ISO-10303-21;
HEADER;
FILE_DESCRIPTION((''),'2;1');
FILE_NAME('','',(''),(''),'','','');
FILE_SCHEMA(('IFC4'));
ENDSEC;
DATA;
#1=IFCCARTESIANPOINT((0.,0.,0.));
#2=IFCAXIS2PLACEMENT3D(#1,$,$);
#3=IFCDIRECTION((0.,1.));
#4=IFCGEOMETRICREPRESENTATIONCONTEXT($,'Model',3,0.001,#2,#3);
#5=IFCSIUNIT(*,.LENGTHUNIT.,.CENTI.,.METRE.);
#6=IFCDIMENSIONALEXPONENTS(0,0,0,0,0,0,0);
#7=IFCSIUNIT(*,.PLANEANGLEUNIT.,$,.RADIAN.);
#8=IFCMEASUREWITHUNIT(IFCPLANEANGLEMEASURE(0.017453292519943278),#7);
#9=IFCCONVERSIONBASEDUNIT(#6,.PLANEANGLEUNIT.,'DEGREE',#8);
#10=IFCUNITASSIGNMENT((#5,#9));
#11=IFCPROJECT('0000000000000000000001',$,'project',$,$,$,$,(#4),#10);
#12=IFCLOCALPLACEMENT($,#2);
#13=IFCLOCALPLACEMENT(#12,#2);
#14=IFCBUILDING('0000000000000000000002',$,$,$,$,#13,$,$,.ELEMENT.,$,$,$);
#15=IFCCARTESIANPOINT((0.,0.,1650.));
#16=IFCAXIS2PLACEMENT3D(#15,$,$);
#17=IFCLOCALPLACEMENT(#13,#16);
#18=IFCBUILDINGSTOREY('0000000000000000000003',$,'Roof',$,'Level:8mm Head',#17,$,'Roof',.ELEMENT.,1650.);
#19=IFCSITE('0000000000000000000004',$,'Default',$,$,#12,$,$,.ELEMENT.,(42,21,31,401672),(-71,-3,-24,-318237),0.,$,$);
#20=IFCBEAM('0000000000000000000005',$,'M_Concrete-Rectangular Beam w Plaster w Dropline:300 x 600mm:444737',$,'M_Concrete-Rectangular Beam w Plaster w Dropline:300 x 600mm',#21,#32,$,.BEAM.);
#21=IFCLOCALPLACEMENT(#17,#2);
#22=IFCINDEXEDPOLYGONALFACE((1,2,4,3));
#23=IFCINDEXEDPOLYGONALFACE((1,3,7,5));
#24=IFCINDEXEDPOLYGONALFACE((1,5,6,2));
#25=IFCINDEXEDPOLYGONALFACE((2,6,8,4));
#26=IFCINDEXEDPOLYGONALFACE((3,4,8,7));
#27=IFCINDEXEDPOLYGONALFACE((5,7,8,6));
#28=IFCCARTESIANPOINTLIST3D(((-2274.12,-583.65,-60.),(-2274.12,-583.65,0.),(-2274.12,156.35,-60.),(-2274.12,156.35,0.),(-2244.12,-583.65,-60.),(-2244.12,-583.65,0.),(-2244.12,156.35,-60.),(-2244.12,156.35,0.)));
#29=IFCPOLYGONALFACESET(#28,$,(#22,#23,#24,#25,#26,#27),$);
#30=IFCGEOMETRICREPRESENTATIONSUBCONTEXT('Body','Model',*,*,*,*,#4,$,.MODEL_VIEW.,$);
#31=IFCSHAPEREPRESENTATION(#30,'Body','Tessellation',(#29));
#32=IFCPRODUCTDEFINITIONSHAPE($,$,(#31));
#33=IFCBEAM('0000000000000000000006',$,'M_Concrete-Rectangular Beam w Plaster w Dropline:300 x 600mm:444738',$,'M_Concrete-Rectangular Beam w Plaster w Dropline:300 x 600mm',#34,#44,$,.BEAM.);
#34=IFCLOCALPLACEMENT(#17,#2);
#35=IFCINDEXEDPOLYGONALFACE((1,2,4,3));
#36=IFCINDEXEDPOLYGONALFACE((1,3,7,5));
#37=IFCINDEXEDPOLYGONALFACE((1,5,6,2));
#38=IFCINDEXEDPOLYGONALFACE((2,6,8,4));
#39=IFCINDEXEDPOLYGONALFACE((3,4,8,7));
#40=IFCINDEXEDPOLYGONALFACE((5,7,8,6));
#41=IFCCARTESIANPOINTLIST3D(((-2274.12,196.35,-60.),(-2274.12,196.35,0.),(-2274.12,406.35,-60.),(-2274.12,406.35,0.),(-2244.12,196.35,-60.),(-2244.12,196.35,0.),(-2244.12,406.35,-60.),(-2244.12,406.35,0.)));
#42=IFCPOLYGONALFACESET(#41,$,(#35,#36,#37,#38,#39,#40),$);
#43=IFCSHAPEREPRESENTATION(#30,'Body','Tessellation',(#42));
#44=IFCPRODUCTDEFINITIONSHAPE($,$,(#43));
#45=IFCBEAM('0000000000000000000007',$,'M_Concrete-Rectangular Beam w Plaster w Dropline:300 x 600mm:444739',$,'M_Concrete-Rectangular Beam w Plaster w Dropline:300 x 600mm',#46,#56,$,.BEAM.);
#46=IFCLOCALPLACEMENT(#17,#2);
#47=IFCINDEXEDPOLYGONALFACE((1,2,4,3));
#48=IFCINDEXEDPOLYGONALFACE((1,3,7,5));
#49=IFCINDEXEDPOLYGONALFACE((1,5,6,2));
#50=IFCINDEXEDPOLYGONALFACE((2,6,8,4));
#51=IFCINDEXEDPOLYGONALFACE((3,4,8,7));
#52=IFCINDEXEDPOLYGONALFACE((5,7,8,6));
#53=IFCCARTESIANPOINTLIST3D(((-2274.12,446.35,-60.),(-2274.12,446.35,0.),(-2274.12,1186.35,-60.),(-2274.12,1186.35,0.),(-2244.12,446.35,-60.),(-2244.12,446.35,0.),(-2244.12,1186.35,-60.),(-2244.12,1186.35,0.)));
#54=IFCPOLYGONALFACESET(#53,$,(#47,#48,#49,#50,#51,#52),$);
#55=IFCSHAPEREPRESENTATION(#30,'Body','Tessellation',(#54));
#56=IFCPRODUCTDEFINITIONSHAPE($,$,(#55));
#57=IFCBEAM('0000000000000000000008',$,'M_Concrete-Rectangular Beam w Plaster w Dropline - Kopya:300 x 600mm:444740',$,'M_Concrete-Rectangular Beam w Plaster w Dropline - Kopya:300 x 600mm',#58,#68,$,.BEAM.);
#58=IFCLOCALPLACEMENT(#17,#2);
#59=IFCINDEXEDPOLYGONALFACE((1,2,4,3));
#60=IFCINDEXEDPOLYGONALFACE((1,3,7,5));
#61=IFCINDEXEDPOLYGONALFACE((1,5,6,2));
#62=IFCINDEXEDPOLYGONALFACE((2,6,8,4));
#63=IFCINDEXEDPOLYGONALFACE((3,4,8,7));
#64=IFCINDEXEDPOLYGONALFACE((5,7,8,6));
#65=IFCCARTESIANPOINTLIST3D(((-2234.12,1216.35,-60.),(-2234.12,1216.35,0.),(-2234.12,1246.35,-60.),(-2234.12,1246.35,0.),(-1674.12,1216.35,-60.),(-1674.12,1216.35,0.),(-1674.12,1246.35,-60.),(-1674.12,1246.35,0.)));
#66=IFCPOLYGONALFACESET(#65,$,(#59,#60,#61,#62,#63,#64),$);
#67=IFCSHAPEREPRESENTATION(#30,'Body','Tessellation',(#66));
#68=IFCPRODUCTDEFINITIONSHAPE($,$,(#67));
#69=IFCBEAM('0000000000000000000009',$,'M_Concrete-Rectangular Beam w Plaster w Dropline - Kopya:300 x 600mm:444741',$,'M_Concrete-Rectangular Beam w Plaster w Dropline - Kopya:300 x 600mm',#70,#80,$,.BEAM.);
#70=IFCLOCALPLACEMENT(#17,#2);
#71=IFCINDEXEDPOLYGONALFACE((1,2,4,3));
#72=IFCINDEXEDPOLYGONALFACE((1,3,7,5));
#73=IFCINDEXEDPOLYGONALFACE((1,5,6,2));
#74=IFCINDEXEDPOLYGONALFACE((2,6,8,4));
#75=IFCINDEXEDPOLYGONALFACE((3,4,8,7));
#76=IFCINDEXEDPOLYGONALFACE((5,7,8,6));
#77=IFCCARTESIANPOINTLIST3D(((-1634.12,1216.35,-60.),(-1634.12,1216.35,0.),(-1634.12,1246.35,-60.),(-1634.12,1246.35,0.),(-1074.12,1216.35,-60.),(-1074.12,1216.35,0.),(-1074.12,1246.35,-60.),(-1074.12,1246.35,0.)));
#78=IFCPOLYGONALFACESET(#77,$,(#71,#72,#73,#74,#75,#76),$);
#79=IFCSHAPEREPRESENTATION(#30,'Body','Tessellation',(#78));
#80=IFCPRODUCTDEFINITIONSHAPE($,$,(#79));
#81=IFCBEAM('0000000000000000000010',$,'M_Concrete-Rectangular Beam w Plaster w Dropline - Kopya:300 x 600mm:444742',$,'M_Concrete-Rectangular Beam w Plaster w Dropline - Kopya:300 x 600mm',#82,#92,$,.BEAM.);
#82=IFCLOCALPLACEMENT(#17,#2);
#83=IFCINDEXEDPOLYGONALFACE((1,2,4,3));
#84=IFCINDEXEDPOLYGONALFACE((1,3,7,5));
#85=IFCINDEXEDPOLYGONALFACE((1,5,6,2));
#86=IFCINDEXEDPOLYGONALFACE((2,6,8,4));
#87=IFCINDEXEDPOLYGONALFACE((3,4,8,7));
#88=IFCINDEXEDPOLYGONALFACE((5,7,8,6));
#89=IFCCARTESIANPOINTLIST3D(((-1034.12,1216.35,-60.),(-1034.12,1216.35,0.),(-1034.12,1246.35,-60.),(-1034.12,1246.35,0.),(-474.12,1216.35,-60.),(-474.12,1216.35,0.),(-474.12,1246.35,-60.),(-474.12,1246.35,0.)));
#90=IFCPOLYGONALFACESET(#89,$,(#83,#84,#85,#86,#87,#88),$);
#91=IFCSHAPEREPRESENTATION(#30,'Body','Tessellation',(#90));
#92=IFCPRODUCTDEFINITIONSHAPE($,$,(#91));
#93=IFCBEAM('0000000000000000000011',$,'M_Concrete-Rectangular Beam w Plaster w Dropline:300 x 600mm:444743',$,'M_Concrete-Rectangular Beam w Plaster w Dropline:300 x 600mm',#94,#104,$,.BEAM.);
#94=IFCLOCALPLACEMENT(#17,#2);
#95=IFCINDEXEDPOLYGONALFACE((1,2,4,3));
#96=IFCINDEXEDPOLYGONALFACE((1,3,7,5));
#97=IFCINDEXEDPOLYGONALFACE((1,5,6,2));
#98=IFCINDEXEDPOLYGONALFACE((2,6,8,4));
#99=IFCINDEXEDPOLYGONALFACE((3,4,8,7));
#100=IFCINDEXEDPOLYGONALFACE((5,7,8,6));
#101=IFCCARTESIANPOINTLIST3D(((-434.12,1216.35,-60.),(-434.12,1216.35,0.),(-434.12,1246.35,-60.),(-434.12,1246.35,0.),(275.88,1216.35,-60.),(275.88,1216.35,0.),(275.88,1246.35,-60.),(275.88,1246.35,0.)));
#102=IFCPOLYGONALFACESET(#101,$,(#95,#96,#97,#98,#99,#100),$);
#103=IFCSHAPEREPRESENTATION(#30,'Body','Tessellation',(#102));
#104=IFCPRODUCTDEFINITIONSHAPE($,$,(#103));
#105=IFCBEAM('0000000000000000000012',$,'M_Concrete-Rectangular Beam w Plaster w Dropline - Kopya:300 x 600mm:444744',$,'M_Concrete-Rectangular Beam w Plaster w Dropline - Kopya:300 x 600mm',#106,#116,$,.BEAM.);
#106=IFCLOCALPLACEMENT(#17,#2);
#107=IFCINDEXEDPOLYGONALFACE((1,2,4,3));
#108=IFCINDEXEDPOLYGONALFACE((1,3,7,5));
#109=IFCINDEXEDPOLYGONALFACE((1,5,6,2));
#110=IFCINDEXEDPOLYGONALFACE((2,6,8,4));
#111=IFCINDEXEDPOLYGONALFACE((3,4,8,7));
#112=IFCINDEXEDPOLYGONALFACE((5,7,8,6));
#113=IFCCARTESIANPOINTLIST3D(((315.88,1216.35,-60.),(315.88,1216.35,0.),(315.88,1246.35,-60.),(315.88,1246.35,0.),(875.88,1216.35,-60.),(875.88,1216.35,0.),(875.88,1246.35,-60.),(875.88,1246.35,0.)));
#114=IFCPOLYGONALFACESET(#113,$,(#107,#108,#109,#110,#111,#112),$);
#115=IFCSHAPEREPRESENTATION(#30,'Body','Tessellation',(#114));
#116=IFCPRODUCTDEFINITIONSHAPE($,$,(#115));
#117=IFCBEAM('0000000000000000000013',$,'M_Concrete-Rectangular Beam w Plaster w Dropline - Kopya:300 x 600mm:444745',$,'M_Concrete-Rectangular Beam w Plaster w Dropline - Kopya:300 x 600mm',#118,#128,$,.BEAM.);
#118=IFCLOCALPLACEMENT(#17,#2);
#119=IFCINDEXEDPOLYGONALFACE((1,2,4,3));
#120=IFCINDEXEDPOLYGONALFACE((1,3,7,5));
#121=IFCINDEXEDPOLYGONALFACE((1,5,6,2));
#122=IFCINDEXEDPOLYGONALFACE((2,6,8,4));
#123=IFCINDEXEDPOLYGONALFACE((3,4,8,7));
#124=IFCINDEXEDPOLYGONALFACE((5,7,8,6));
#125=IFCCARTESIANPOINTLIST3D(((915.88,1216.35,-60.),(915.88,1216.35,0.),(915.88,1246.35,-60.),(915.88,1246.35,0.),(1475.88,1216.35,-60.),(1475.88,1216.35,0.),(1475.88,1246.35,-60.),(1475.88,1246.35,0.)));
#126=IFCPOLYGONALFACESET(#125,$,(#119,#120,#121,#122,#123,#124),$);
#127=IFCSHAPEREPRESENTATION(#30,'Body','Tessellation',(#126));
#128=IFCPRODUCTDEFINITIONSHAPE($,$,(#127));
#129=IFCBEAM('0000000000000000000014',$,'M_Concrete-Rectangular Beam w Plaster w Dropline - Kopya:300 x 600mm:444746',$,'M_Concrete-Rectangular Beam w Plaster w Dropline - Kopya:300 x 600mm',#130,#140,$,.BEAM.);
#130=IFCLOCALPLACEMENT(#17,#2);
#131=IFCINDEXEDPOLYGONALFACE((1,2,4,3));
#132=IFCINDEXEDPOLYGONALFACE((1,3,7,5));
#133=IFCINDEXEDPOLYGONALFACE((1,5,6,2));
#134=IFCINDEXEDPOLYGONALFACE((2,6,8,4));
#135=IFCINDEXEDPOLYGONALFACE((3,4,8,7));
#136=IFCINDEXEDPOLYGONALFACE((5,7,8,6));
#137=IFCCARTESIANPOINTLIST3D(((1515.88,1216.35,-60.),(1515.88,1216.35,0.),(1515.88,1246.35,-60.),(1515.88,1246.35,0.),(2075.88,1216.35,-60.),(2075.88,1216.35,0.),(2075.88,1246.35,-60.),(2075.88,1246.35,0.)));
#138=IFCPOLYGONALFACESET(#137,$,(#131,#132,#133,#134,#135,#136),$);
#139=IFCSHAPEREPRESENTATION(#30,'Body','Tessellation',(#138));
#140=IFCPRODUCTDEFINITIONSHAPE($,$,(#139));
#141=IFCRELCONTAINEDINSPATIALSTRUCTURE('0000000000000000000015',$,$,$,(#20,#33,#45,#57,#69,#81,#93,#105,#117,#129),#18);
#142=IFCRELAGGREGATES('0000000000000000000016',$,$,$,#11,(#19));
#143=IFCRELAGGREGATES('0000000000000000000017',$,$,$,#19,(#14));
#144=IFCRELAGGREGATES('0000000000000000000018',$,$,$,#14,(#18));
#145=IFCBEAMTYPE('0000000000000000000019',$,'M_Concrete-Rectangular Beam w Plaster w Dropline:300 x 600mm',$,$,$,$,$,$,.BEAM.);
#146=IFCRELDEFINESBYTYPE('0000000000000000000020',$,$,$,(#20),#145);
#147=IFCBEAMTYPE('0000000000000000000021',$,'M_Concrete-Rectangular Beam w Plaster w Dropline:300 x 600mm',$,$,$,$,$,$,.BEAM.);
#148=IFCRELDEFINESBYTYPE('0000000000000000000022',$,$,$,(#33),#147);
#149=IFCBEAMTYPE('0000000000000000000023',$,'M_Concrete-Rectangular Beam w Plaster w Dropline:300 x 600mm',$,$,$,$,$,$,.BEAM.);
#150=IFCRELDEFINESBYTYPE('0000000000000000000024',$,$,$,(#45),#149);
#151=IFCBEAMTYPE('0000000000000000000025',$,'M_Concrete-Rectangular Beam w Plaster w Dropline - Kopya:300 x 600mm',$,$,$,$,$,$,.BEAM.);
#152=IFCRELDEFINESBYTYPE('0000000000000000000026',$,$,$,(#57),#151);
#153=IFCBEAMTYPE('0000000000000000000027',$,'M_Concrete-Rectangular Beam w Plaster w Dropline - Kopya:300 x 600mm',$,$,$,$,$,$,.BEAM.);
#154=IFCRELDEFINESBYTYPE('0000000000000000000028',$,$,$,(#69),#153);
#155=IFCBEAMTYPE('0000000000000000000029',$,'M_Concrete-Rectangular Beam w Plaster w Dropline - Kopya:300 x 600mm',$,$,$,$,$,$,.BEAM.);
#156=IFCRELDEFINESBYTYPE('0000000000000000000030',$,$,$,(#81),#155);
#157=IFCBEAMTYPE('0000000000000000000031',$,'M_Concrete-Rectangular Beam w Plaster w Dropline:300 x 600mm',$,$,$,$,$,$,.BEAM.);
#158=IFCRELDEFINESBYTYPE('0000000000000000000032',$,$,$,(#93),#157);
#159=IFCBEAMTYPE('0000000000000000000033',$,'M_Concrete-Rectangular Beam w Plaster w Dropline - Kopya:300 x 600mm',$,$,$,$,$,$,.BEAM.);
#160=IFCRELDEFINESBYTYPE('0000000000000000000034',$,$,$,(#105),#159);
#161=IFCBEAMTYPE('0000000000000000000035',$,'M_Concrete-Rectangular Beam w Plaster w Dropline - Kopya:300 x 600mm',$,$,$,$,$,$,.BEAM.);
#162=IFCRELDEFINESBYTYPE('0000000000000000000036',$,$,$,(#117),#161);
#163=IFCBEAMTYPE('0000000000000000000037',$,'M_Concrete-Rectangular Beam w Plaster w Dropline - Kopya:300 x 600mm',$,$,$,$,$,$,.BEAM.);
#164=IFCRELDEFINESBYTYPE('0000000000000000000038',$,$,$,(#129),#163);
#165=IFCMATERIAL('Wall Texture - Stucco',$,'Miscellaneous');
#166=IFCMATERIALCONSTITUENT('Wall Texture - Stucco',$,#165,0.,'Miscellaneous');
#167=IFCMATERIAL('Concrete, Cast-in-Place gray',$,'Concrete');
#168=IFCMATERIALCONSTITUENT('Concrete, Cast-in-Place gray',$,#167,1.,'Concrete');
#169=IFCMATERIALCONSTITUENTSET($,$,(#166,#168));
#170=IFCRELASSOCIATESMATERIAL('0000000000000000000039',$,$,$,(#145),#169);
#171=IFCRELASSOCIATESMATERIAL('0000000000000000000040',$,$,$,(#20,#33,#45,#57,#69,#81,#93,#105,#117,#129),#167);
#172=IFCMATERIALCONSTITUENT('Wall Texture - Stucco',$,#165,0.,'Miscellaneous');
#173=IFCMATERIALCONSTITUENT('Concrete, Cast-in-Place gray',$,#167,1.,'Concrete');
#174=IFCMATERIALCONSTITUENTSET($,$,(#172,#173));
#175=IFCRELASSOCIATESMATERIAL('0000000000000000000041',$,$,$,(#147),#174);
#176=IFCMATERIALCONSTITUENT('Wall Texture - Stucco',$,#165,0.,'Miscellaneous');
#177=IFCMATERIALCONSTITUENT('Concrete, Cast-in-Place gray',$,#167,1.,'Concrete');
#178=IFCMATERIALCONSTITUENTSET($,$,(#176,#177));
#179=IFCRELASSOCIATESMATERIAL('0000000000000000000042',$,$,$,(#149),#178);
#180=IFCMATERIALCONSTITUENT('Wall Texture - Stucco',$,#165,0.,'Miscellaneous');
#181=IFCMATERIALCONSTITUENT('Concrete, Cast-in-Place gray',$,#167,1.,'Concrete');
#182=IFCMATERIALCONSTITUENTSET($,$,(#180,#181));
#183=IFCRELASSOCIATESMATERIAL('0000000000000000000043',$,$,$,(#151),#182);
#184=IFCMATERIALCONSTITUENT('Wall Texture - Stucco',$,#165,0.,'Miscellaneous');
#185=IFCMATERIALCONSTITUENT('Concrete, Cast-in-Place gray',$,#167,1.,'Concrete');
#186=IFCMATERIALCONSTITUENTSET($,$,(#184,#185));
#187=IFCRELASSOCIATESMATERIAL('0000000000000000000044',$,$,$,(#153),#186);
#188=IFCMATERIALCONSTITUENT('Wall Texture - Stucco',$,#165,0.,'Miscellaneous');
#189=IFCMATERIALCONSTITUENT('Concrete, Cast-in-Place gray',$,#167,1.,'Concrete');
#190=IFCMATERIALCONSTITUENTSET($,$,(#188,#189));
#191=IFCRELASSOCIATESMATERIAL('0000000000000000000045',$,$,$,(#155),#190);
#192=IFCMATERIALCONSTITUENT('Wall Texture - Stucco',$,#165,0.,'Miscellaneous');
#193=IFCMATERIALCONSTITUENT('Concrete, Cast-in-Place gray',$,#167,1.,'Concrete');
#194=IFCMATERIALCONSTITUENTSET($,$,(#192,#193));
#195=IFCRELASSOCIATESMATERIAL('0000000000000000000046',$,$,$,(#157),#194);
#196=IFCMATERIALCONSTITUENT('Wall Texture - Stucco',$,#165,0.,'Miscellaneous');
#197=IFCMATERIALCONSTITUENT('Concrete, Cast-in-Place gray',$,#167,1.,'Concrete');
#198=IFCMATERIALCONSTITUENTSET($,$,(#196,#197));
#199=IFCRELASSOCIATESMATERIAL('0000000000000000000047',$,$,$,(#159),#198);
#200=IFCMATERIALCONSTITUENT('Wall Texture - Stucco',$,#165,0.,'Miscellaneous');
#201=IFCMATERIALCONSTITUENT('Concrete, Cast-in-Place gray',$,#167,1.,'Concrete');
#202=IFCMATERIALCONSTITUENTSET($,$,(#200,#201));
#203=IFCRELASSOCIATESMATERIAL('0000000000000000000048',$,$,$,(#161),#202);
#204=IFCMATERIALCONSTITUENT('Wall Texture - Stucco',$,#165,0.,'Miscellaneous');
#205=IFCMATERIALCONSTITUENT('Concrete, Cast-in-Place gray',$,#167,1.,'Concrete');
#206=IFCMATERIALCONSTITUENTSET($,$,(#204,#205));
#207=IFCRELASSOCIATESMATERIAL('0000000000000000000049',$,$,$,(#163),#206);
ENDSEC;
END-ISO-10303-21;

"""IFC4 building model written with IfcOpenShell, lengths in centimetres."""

from ifc_helpers import new_model, entity, si_unit, converted_unit, direction, frame, origin, place, context, subcontext, project, spatial, indexed_curve, outline, extrude, source, transform, mapped, material, constituent, constituent_set, type_object, type_shapes, element, save


model = new_model("IFC4")

# Units and contexts
model_context = context("Model", 3, precision=0.001, world=origin(), true_north=direction((0.0, 1.0)))
body_context = subcontext(model_context, "Body", "Model", "MODEL_VIEW")
ifc_project = project(units=[si_unit("LENGTHUNIT", "METRE", prefix="CENTI"), converted_unit("PLANEANGLEUNIT", "DEGREE", entity("IfcPlaneAngleMeasure", 0.017453292519943278), si_unit("PLANEANGLEUNIT", "RADIAN"), dimensions=[0, 0, 0, 0, 0, 0, 0])], contexts=[model_context])

# Site, building, storey
site_placement = place(None, origin())
site = spatial("IfcSite", under=ifc_project, at=site_placement, Name="Default", CompositionType="ELEMENT", RefLatitude=(42, 21, 31, 401672), RefLongitude=(-71, -3, -24, -318237), RefElevation=0.0)
building_placement = place(site_placement, origin())
building = spatial("IfcBuilding", under=site, at=building_placement, CompositionType="ELEMENT")
storey_placement = place(building_placement, frame((0.0, 0.0, 1650.0)))
storey = spatial("IfcBuildingStorey", under=building, at=storey_placement, Name="Roof", ObjectType="Level:8mm Head", LongName="Roof", CompositionType="ELEMENT", Elevation=1650.0)

# Beams
ifc_material_1 = material(Name="Concrete, Cast-in-Place gray", Category="Concrete")
ifc_material_2 = material(Name="Wall Texture - Stucco", Category="Miscellaneous")
ifc_constituent_1 = constituent(ifc_material_2, Name="Wall Texture - Stucco", Category="Miscellaneous", fraction=0.0)
ifc_constituent_2 = constituent(ifc_material_1, Name="Concrete, Cast-in-Place gray", Category="Concrete", fraction=1.0)
ifc_constituent_set_1 = constituent_set(constituents=[ifc_constituent_1, ifc_constituent_2])
beam_type_1 = type_object("IfcBeamType", Name="M_Concrete-Rectangular Beam w Plaster w Dropline:300 x 600mm", PredefinedType="BEAM", material=ifc_constituent_set_1)
shared_shape_1 = source(origin(), body_context, "Body", "SweptSolid", [
    extrude(outline(indexed_curve([(-15.0, -30.0), (15.0, -30.0), (15.0, 30.0), (-15.0, 30.0), (-15.0, -30.0)], self_intersect=False)), frame((-2259.12, -583.65, 1620.0), z_axis=(0.0, 1.0, 0.0), x_axis=(-1.0, 0.0, 0.0)), (0.0, 0.0, 1.0), 740.0),
])
type_shapes(beam_type_1, [shared_shape_1])
beam_1_placement = place(storey_placement, frame((0.0, 0.0, -1650.0)))
element("IfcBeam", 1, at=beam_1_placement, inside=storey, type_object=beam_type_1, material=ifc_material_1, Name="M_Concrete-Rectangular Beam w Plaster w Dropline:300 x 600mm:444737", ObjectType="M_Concrete-Rectangular Beam w Plaster w Dropline:300 x 600mm", PredefinedType="BEAM", context=body_context, shape_type="MappedRepresentation", body=[
    mapped(shared_shape_1, transform((0.0, 0.0, 0.0), scale=1.0)),
])
ifc_constituent_3 = constituent(ifc_material_2, Name="Wall Texture - Stucco", Category="Miscellaneous", fraction=0.0)
ifc_constituent_4 = constituent(ifc_material_1, Name="Concrete, Cast-in-Place gray", Category="Concrete", fraction=1.0)
ifc_constituent_set_2 = constituent_set(constituents=[ifc_constituent_3, ifc_constituent_4])
beam_type_2 = type_object("IfcBeamType", Name="M_Concrete-Rectangular Beam w Plaster w Dropline:300 x 600mm", PredefinedType="BEAM", material=ifc_constituent_set_2)
shared_shape_2 = source(origin(), body_context, "Body", "SweptSolid", [
    extrude(outline(indexed_curve([(-15.0, -30.0), (15.0, -30.0), (15.0, 30.0), (-15.0, 30.0), (-15.0, -30.0)], self_intersect=False)), frame((-2259.12, 196.35, 1620.0), z_axis=(0.0, 1.0, 0.0), x_axis=(-1.0, 0.0, 0.0)), (0.0, 0.0, 1.0), 210.0),
])
type_shapes(beam_type_2, [shared_shape_2])
beam_2_placement = place(storey_placement, frame((0.0, 0.0, -1650.0)))
element("IfcBeam", 2, at=beam_2_placement, inside=storey, type_object=beam_type_2, material=ifc_material_1, Name="M_Concrete-Rectangular Beam w Plaster w Dropline:300 x 600mm:444738", ObjectType="M_Concrete-Rectangular Beam w Plaster w Dropline:300 x 600mm", PredefinedType="BEAM", context=body_context, shape_type="MappedRepresentation", body=[
    mapped(shared_shape_2, transform((0.0, 0.0, 0.0), scale=1.0)),
])
ifc_constituent_5 = constituent(ifc_material_2, Name="Wall Texture - Stucco", Category="Miscellaneous", fraction=0.0)
ifc_constituent_6 = constituent(ifc_material_1, Name="Concrete, Cast-in-Place gray", Category="Concrete", fraction=1.0)
ifc_constituent_set_3 = constituent_set(constituents=[ifc_constituent_5, ifc_constituent_6])
beam_type_3 = type_object("IfcBeamType", Name="M_Concrete-Rectangular Beam w Plaster w Dropline:300 x 600mm", PredefinedType="BEAM", material=ifc_constituent_set_3)
shared_shape_3 = source(origin(), body_context, "Body", "SweptSolid", [
    extrude(outline(indexed_curve([(-15.0, -30.0), (15.0, -30.0), (15.0, 30.0), (-15.0, 30.0), (-15.0, -30.0)], self_intersect=False)), frame((-2259.12, 446.35, 1620.0), z_axis=(0.0, 1.0, 0.0), x_axis=(-1.0, 0.0, 0.0)), (0.0, 0.0, 1.0), 740.0),
])
type_shapes(beam_type_3, [shared_shape_3])
beam_3_placement = place(storey_placement, frame((0.0, 0.0, -1650.0)))
element("IfcBeam", 3, at=beam_3_placement, inside=storey, type_object=beam_type_3, material=ifc_material_1, Name="M_Concrete-Rectangular Beam w Plaster w Dropline:300 x 600mm:444739", ObjectType="M_Concrete-Rectangular Beam w Plaster w Dropline:300 x 600mm", PredefinedType="BEAM", context=body_context, shape_type="MappedRepresentation", body=[
    mapped(shared_shape_3, transform((0.0, 0.0, 0.0), scale=1.0)),
])
ifc_constituent_7 = constituent(ifc_material_2, Name="Wall Texture - Stucco", Category="Miscellaneous", fraction=0.0)
ifc_constituent_8 = constituent(ifc_material_1, Name="Concrete, Cast-in-Place gray", Category="Concrete", fraction=1.0)
ifc_constituent_set_4 = constituent_set(constituents=[ifc_constituent_7, ifc_constituent_8])
beam_type_4 = type_object("IfcBeamType", Name="M_Concrete-Rectangular Beam w Plaster w Dropline - Kopya:300 x 600mm", PredefinedType="BEAM", material=ifc_constituent_set_4)
shared_shape_4 = source(origin(), body_context, "Body", "SweptSolid", [
    extrude(outline(indexed_curve([(-30.0, -15.0), (30.0, -15.0), (30.0, 15.0), (-30.0, 15.0), (-30.0, -15.0)], self_intersect=False)), frame((-2234.12, 1231.35, 1620.0), z_axis=(1.0, 0.0, 0.0), x_axis=(0.0, 0.0, -1.0)), (0.0, 0.0, 1.0), 560.0),
])
type_shapes(beam_type_4, [shared_shape_4])
beam_4_placement = place(storey_placement, frame((0.0, 0.0, -1650.0)))
element("IfcBeam", 4, at=beam_4_placement, inside=storey, type_object=beam_type_4, material=ifc_material_1, Name="M_Concrete-Rectangular Beam w Plaster w Dropline - Kopya:300 x 600mm:444740", ObjectType="M_Concrete-Rectangular Beam w Plaster w Dropline - Kopya:300 x 600mm", PredefinedType="BEAM", context=body_context, shape_type="MappedRepresentation", body=[
    mapped(shared_shape_4, transform((0.0, 0.0, 0.0), scale=1.0)),
])
ifc_constituent_9 = constituent(ifc_material_2, Name="Wall Texture - Stucco", Category="Miscellaneous", fraction=0.0)
ifc_constituent_10 = constituent(ifc_material_1, Name="Concrete, Cast-in-Place gray", Category="Concrete", fraction=1.0)
ifc_constituent_set_5 = constituent_set(constituents=[ifc_constituent_9, ifc_constituent_10])
beam_type_5 = type_object("IfcBeamType", Name="M_Concrete-Rectangular Beam w Plaster w Dropline - Kopya:300 x 600mm", PredefinedType="BEAM", material=ifc_constituent_set_5)
shared_shape_5 = source(origin(), body_context, "Body", "SweptSolid", [
    extrude(outline(indexed_curve([(-30.0, -15.0), (30.0, -15.0), (30.0, 15.0), (-30.0, 15.0), (-30.0, -15.0)], self_intersect=False)), frame((-1634.12, 1231.35, 1620.0), z_axis=(1.0, 0.0, 0.0), x_axis=(0.0, 0.0, -1.0)), (0.0, 0.0, 1.0), 560.0),
])
type_shapes(beam_type_5, [shared_shape_5])
beam_5_placement = place(storey_placement, frame((0.0, 0.0, -1650.0)))
element("IfcBeam", 5, at=beam_5_placement, inside=storey, type_object=beam_type_5, material=ifc_material_1, Name="M_Concrete-Rectangular Beam w Plaster w Dropline - Kopya:300 x 600mm:444741", ObjectType="M_Concrete-Rectangular Beam w Plaster w Dropline - Kopya:300 x 600mm", PredefinedType="BEAM", context=body_context, shape_type="MappedRepresentation", body=[
    mapped(shared_shape_5, transform((0.0, 0.0, 0.0), scale=1.0)),
])
ifc_constituent_11 = constituent(ifc_material_2, Name="Wall Texture - Stucco", Category="Miscellaneous", fraction=0.0)
ifc_constituent_12 = constituent(ifc_material_1, Name="Concrete, Cast-in-Place gray", Category="Concrete", fraction=1.0)
ifc_constituent_set_6 = constituent_set(constituents=[ifc_constituent_11, ifc_constituent_12])
beam_type_6 = type_object("IfcBeamType", Name="M_Concrete-Rectangular Beam w Plaster w Dropline - Kopya:300 x 600mm", PredefinedType="BEAM", material=ifc_constituent_set_6)
shared_shape_6 = source(origin(), body_context, "Body", "SweptSolid", [
    extrude(outline(indexed_curve([(-30.0, -15.0), (30.0, -15.0), (30.0, 15.0), (-30.0, 15.0), (-30.0, -15.0)], self_intersect=False)), frame((-1034.12, 1231.35, 1620.0), z_axis=(1.0, 0.0, 0.0), x_axis=(0.0, 0.0, -1.0)), (0.0, 0.0, 1.0), 560.0),
])
type_shapes(beam_type_6, [shared_shape_6])
beam_6_placement = place(storey_placement, frame((0.0, 0.0, -1650.0)))
element("IfcBeam", 6, at=beam_6_placement, inside=storey, type_object=beam_type_6, material=ifc_material_1, Name="M_Concrete-Rectangular Beam w Plaster w Dropline - Kopya:300 x 600mm:444742", ObjectType="M_Concrete-Rectangular Beam w Plaster w Dropline - Kopya:300 x 600mm", PredefinedType="BEAM", context=body_context, shape_type="MappedRepresentation", body=[
    mapped(shared_shape_6, transform((0.0, 0.0, 0.0), scale=1.0)),
])
ifc_constituent_13 = constituent(ifc_material_2, Name="Wall Texture - Stucco", Category="Miscellaneous", fraction=0.0)
ifc_constituent_14 = constituent(ifc_material_1, Name="Concrete, Cast-in-Place gray", Category="Concrete", fraction=1.0)
ifc_constituent_set_7 = constituent_set(constituents=[ifc_constituent_13, ifc_constituent_14])
beam_type_7 = type_object("IfcBeamType", Name="M_Concrete-Rectangular Beam w Plaster w Dropline:300 x 600mm", PredefinedType="BEAM", material=ifc_constituent_set_7)
shared_shape_7 = source(origin(), body_context, "Body", "SweptSolid", [
    extrude(outline(indexed_curve([(-30.0, -15.0), (30.0, -15.0), (30.0, 15.0), (-30.0, 15.0), (-30.0, -15.0)], self_intersect=False)), frame((-434.12, 1231.35, 1620.0), z_axis=(1.0, 0.0, 0.0), x_axis=(0.0, 0.0, -1.0)), (0.0, 0.0, 1.0), 710.0),
])
type_shapes(beam_type_7, [shared_shape_7])
beam_7_placement = place(storey_placement, frame((0.0, 0.0, -1650.0)))
element("IfcBeam", 7, at=beam_7_placement, inside=storey, type_object=beam_type_7, material=ifc_material_1, Name="M_Concrete-Rectangular Beam w Plaster w Dropline:300 x 600mm:444743", ObjectType="M_Concrete-Rectangular Beam w Plaster w Dropline:300 x 600mm", PredefinedType="BEAM", context=body_context, shape_type="MappedRepresentation", body=[
    mapped(shared_shape_7, transform((0.0, 0.0, 0.0), scale=1.0)),
])
ifc_constituent_15 = constituent(ifc_material_2, Name="Wall Texture - Stucco", Category="Miscellaneous", fraction=0.0)
ifc_constituent_16 = constituent(ifc_material_1, Name="Concrete, Cast-in-Place gray", Category="Concrete", fraction=1.0)
ifc_constituent_set_8 = constituent_set(constituents=[ifc_constituent_15, ifc_constituent_16])
beam_type_8 = type_object("IfcBeamType", Name="M_Concrete-Rectangular Beam w Plaster w Dropline - Kopya:300 x 600mm", PredefinedType="BEAM", material=ifc_constituent_set_8)
shared_shape_8 = source(origin(), body_context, "Body", "SweptSolid", [
    extrude(outline(indexed_curve([(-30.0, -15.0), (30.0, -15.0), (30.0, 15.0), (-30.0, 15.0), (-30.0, -15.0)], self_intersect=False)), frame((315.88, 1231.35, 1620.0), z_axis=(1.0, 0.0, 0.0), x_axis=(0.0, 0.0, -1.0)), (0.0, 0.0, 1.0), 560.0),
])
type_shapes(beam_type_8, [shared_shape_8])
beam_8_placement = place(storey_placement, frame((0.0, 0.0, -1650.0)))
element("IfcBeam", 8, at=beam_8_placement, inside=storey, type_object=beam_type_8, material=ifc_material_1, Name="M_Concrete-Rectangular Beam w Plaster w Dropline - Kopya:300 x 600mm:444744", ObjectType="M_Concrete-Rectangular Beam w Plaster w Dropline - Kopya:300 x 600mm", PredefinedType="BEAM", context=body_context, shape_type="MappedRepresentation", body=[
    mapped(shared_shape_8, transform((0.0, 0.0, 0.0), scale=1.0)),
])
ifc_constituent_17 = constituent(ifc_material_2, Name="Wall Texture - Stucco", Category="Miscellaneous", fraction=0.0)
ifc_constituent_18 = constituent(ifc_material_1, Name="Concrete, Cast-in-Place gray", Category="Concrete", fraction=1.0)
ifc_constituent_set_9 = constituent_set(constituents=[ifc_constituent_17, ifc_constituent_18])
beam_type_9 = type_object("IfcBeamType", Name="M_Concrete-Rectangular Beam w Plaster w Dropline - Kopya:300 x 600mm", PredefinedType="BEAM", material=ifc_constituent_set_9)
shared_shape_9 = source(origin(), body_context, "Body", "SweptSolid", [
    extrude(outline(indexed_curve([(-30.0, -15.0), (30.0, -15.0), (30.0, 15.0), (-30.0, 15.0), (-30.0, -15.0)], self_intersect=False)), frame((915.88, 1231.35, 1620.0), z_axis=(1.0, 0.0, 0.0), x_axis=(0.0, 0.0, -1.0)), (0.0, 0.0, 1.0), 560.0),
])
type_shapes(beam_type_9, [shared_shape_9])
beam_9_placement = place(storey_placement, frame((0.0, 0.0, -1650.0)))
element("IfcBeam", 9, at=beam_9_placement, inside=storey, type_object=beam_type_9, material=ifc_material_1, Name="M_Concrete-Rectangular Beam w Plaster w Dropline - Kopya:300 x 600mm:444745", ObjectType="M_Concrete-Rectangular Beam w Plaster w Dropline - Kopya:300 x 600mm", PredefinedType="BEAM", context=body_context, shape_type="MappedRepresentation", body=[
    mapped(shared_shape_9, transform((0.0, 0.0, 0.0), scale=1.0)),
])
ifc_constituent_19 = constituent(ifc_material_2, Name="Wall Texture - Stucco", Category="Miscellaneous", fraction=0.0)
ifc_constituent_20 = constituent(ifc_material_1, Name="Concrete, Cast-in-Place gray", Category="Concrete", fraction=1.0)
ifc_constituent_set_10 = constituent_set(constituents=[ifc_constituent_19, ifc_constituent_20])
beam_type_10 = type_object("IfcBeamType", Name="M_Concrete-Rectangular Beam w Plaster w Dropline - Kopya:300 x 600mm", PredefinedType="BEAM", material=ifc_constituent_set_10)
shared_shape_10 = source(origin(), body_context, "Body", "SweptSolid", [
    extrude(outline(indexed_curve([(-30.0, -15.0), (30.0, -15.0), (30.0, 15.0), (-30.0, 15.0), (-30.0, -15.0)], self_intersect=False)), frame((1515.88, 1231.35, 1620.0), z_axis=(1.0, 0.0, 0.0), x_axis=(0.0, 0.0, -1.0)), (0.0, 0.0, 1.0), 560.0),
])
type_shapes(beam_type_10, [shared_shape_10])
beam_10_placement = place(storey_placement, frame((0.0, 0.0, -1650.0)))
element("IfcBeam", 10, at=beam_10_placement, inside=storey, type_object=beam_type_10, material=ifc_material_1, Name="M_Concrete-Rectangular Beam w Plaster w Dropline - Kopya:300 x 600mm:444746", ObjectType="M_Concrete-Rectangular Beam w Plaster w Dropline - Kopya:300 x 600mm", PredefinedType="BEAM", context=body_context, shape_type="MappedRepresentation", body=[
    mapped(shared_shape_10, transform((0.0, 0.0, 0.0), scale=1.0)),
])

save(model, "model.ifc")
